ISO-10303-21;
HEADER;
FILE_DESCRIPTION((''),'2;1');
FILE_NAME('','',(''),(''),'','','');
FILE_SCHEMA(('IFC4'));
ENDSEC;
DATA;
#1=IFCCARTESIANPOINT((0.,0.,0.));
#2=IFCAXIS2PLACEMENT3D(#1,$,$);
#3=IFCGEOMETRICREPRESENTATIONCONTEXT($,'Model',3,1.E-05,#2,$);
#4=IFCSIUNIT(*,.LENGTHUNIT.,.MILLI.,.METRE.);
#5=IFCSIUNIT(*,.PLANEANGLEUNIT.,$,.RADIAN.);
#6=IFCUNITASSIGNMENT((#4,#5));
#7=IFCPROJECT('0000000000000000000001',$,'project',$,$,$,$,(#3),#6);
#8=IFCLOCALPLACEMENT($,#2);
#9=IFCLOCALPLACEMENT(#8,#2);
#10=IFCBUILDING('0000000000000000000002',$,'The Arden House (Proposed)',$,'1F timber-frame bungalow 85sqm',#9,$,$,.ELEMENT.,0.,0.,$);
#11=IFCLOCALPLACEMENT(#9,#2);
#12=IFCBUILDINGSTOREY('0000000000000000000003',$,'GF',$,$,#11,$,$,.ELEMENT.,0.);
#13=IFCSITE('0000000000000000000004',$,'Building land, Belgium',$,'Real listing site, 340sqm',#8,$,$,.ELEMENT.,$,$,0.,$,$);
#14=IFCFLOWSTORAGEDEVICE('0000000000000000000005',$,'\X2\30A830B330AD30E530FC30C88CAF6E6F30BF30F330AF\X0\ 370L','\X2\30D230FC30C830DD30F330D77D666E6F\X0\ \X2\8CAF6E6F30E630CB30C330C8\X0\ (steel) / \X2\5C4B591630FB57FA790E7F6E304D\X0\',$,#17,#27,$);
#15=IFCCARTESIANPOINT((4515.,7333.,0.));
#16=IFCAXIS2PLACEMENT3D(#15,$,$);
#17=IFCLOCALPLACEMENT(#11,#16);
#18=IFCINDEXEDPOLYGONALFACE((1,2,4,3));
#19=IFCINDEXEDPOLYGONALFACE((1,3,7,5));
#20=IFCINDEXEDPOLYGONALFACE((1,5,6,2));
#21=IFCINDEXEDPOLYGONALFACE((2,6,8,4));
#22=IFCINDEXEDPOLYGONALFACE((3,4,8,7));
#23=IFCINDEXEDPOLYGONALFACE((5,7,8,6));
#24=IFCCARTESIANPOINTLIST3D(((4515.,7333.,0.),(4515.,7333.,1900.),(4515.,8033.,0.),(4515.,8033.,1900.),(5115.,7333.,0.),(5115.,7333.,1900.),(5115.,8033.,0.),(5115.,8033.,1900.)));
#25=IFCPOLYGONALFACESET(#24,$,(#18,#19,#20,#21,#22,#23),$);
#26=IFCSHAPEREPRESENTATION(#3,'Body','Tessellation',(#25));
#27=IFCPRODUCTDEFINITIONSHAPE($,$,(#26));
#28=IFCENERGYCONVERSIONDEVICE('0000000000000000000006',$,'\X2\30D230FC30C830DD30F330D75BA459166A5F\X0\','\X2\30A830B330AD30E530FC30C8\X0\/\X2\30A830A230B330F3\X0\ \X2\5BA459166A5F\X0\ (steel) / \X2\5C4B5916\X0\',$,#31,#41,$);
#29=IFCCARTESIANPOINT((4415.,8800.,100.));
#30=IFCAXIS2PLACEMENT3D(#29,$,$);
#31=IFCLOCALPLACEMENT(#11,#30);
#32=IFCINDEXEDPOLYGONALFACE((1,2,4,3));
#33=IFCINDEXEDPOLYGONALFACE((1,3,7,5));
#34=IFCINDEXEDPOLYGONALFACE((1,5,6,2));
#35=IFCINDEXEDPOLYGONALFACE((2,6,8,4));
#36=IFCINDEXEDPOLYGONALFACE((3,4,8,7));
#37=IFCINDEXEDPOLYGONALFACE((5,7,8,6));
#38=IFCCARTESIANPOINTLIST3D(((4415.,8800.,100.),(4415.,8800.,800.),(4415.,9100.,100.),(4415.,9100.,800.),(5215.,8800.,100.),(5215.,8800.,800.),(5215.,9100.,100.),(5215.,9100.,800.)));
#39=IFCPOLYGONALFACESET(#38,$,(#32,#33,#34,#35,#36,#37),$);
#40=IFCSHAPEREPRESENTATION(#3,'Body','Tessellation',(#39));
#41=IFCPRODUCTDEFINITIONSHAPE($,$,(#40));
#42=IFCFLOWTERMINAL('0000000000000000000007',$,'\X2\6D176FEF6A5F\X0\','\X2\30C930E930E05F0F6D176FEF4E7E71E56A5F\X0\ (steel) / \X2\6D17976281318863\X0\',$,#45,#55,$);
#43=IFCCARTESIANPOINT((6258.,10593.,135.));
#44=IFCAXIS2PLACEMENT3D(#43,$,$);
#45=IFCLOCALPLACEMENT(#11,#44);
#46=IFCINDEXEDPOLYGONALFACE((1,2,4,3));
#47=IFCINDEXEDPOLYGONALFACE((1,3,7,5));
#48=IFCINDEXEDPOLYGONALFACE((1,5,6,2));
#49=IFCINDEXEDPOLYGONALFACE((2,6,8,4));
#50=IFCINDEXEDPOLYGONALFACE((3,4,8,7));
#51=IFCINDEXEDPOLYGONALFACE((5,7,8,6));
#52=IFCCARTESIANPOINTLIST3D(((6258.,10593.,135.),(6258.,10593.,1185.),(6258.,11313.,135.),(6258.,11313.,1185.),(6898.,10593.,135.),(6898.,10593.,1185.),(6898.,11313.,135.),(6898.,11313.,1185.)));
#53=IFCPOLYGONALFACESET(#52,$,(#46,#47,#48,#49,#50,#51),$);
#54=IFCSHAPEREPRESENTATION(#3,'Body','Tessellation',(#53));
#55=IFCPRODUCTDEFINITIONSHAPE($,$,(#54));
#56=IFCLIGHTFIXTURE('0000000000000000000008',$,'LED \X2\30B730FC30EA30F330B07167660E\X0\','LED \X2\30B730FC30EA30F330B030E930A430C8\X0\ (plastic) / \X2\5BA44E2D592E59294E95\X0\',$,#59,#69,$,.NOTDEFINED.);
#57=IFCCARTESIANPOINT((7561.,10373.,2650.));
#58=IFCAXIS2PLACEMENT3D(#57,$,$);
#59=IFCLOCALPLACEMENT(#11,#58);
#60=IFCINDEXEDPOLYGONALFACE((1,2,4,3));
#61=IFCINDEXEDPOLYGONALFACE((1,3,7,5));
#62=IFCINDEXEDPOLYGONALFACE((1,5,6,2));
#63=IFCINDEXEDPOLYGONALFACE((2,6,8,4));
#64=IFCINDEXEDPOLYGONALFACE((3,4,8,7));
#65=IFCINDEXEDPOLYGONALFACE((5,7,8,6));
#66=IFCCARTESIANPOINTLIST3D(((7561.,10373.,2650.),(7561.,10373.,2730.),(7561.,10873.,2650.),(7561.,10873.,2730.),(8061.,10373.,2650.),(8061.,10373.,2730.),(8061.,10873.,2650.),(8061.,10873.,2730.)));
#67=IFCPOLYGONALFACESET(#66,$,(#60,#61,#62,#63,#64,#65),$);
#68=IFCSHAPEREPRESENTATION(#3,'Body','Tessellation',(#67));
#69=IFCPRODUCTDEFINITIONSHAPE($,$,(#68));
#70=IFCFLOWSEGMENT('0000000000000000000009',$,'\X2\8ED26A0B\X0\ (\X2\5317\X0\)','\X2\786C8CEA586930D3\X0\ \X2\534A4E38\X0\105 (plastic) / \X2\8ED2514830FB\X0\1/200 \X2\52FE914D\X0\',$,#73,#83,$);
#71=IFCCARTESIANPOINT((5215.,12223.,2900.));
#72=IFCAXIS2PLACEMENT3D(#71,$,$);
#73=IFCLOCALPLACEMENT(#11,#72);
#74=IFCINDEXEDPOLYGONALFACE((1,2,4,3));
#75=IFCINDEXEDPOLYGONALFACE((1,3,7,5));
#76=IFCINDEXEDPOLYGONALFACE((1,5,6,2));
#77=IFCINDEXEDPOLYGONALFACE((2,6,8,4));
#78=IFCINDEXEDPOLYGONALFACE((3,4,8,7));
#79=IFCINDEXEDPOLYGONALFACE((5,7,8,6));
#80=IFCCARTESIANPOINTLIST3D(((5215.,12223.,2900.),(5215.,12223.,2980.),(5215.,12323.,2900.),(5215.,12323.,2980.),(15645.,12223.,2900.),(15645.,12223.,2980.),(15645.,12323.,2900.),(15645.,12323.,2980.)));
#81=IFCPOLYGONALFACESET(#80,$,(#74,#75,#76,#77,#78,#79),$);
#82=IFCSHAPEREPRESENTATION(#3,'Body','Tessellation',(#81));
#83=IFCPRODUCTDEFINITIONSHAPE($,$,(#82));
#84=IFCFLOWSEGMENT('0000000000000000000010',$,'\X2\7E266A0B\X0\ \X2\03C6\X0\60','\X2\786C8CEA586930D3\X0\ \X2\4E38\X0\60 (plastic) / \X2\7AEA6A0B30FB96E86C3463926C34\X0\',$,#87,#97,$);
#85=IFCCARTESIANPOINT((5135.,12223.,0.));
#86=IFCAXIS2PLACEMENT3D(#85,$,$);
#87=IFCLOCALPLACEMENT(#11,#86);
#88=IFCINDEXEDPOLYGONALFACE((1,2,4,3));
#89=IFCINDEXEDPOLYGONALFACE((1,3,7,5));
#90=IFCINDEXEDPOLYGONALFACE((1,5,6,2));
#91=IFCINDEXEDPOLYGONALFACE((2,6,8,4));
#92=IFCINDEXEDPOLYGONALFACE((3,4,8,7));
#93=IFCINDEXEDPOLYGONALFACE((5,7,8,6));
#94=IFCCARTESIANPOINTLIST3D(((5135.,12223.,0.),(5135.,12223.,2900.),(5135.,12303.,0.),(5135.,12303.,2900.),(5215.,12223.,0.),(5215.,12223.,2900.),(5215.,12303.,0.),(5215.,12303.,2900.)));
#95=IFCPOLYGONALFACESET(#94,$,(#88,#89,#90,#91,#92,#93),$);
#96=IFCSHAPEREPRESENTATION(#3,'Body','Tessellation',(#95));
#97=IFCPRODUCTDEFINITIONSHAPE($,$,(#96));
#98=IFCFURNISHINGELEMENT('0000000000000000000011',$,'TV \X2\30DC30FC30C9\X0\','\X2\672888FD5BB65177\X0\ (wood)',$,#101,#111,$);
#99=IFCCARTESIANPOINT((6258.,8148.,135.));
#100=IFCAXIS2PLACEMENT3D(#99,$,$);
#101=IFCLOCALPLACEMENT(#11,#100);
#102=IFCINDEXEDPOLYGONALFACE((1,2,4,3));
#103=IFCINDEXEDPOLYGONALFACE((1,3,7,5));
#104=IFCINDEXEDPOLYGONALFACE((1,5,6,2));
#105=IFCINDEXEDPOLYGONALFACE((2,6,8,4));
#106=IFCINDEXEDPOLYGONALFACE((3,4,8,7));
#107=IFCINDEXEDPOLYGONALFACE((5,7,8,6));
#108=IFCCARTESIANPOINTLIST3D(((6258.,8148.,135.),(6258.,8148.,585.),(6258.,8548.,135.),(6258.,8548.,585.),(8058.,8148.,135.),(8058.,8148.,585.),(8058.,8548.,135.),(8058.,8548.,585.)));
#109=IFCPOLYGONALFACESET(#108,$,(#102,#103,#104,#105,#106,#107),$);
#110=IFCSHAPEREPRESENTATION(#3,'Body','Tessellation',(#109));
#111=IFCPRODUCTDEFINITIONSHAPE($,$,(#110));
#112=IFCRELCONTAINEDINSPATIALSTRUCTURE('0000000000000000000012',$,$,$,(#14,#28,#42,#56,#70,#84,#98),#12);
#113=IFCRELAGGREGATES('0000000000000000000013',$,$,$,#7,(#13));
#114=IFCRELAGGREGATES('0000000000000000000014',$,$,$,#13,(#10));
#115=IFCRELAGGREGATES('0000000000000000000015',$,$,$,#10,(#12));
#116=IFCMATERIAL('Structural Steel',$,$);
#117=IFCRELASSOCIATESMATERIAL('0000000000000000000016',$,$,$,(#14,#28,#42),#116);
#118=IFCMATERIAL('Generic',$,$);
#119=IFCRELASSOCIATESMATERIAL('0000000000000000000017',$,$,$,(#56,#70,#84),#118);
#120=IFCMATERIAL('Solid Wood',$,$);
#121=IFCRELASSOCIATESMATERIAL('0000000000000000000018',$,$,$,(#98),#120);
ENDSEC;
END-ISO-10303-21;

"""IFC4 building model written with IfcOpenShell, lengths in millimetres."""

from ifc_helpers import new_model, si_unit, frame, frame_2d, origin, place, context, project, spatial, rectangle, extrude, material, element, save


model = new_model("IFC4")

# Units and contexts
model_context = context("Model", 3, precision=1e-05, world=origin())
ifc_project = project(units=[si_unit("LENGTHUNIT", "METRE", prefix="MILLI"), si_unit("PLANEANGLEUNIT", "RADIAN")], contexts=[model_context])

# Site, building, storey
site_placement = place(None, origin())
site = spatial("IfcSite", under=ifc_project, at=site_placement, Name="Building land, Belgium", ObjectType="Real listing site, 340sqm", CompositionType="ELEMENT", RefElevation=0.0)
building_placement = place(site_placement, origin())
building = spatial("IfcBuilding", under=site, at=building_placement, Name="The Arden House (Proposed)", ObjectType="1F timber-frame bungalow 85sqm", CompositionType="ELEMENT", ElevationOfRefHeight=0.0, ElevationOfTerrain=0.0)
storey_placement = place(building_placement, origin())
storey = spatial("IfcBuildingStorey", under=building, at=storey_placement, Name="GF", CompositionType="ELEMENT", Elevation=0.0)

# Shared definitions
ifc_material_1 = material(Name="Solid Wood")

# Shared definitions
ifc_material_2 = material(Name="Structural Steel")

# Shared definitions
ifc_material_3 = material(Name="Generic")

# Flow storage device
flow_storage_device_placement = place(storey_placement, frame((4515.0, 7333.0, 0.0)))
element("IfcFlowStorageDevice", 1, at=flow_storage_device_placement, inside=storey, material=ifc_material_2, Name="エコキュート貯湯タンク 370L", Description="ヒートポンプ給湯 貯湯ユニット (steel) / 屋外・基礎置き", context=model_context, shape_type="SweptSolid", body=[
    extrude(rectangle(XDim=600.0, YDim=700.0, at=frame_2d((300.0, 350.0))), frame((4515.0, 7333.0, 0.0)), (0.0, 0.0, 1.0), 1900.0),
])

# Energy conversion device
energy_conversion_device_placement = place(storey_placement, frame((4415.0, 8800.0, 100.0)))
element("IfcEnergyConversionDevice", 2, at=energy_conversion_device_placement, inside=storey, material=ifc_material_2, Name="ヒートポンプ室外機", Description="エコキュート/エアコン 室外機 (steel) / 屋外", context=model_context, shape_type="SweptSolid", body=[
    extrude(rectangle(XDim=800.0, YDim=300.0, at=frame_2d((400.0, 150.0))), frame((4415.0, 8800.0, 100.0)), (0.0, 0.0, 1.0), 700.0),
])

# Flow terminal
flow_terminal_placement = place(storey_placement, frame((6258.0, 10593.0, 135.0)))
element("IfcFlowTerminal", 3, at=flow_terminal_placement, inside=storey, material=ifc_material_2, Name="洗濯機", Description="ドラム式洗濯乾燥機 (steel) / 洗面脱衣", context=model_context, shape_type="SweptSolid", body=[
    extrude(rectangle(XDim=640.0, YDim=720.0, at=frame_2d((320.0, 360.0))), frame((6258.0, 10593.0, 135.0)), (0.0, 0.0, 1.0), 1050.0),
])

# Light fixture
light_fixture_placement = place(storey_placement, frame((7561.0, 10373.0, 2650.0)))
element("IfcLightFixture", 4, at=light_fixture_placement, inside=storey, material=ifc_material_3, Name="LED シーリング照明", Description="LED シーリングライト (plastic) / 室中央天井", PredefinedType="NOTDEFINED", context=model_context, shape_type="SweptSolid", body=[
    extrude(rectangle(XDim=500.0, YDim=500.0, at=frame_2d((250.0, 250.0))), frame((7561.0, 10373.0, 2650.0)), (0.0, 0.0, 1.0), 80.0),
])

# Flow segments
flow_segment_1_placement = place(storey_placement, frame((5215.0, 12223.0, 2900.0)))
element("IfcFlowSegment", 5, at=flow_segment_1_placement, inside=storey, material=ifc_material_3, Name="軒樋 (北)", Description="硬質塩ビ 半丸105 (plastic) / 軒先・1/200 勾配", context=model_context, shape_type="SweptSolid", body=[
    extrude(rectangle(XDim=10430.0, YDim=100.0, at=frame_2d((5215.0, 50.0))), frame((5215.0, 12223.0, 2900.0)), (0.0, 0.0, 1.0), 80.0),
])
flow_segment_2_placement = place(storey_placement, frame((5135.0, 12223.0, 0.0)))
element("IfcFlowSegment", 6, at=flow_segment_2_placement, inside=storey, material=ifc_material_3, Name="縦樋 φ60", Description="硬質塩ビ 丸60 (plastic) / 竪樋・雨水排水", context=model_context, shape_type="SweptSolid", body=[
    extrude(rectangle(XDim=80.0, YDim=80.0, at=frame_2d((40.0, 40.0))), frame((5135.0, 12223.0, 0.0)), (0.0, 0.0, 1.0), 2900.0),
])

# Furnishing element
furnishing_placement = place(storey_placement, frame((6258.0, 8148.0, 135.0)))
element("IfcFurnishingElement", 7, at=furnishing_placement, inside=storey, material=ifc_material_1, Name="TV ボード", Description="木製家具 (wood)", context=model_context, shape_type="SweptSolid", body=[
    extrude(rectangle(XDim=1800.0, YDim=400.0, at=frame_2d((900.0, 200.0))), frame((6258.0, 8148.0, 135.0)), (0.0, 0.0, 1.0), 450.0),
])

save(model, "model.ifc")
